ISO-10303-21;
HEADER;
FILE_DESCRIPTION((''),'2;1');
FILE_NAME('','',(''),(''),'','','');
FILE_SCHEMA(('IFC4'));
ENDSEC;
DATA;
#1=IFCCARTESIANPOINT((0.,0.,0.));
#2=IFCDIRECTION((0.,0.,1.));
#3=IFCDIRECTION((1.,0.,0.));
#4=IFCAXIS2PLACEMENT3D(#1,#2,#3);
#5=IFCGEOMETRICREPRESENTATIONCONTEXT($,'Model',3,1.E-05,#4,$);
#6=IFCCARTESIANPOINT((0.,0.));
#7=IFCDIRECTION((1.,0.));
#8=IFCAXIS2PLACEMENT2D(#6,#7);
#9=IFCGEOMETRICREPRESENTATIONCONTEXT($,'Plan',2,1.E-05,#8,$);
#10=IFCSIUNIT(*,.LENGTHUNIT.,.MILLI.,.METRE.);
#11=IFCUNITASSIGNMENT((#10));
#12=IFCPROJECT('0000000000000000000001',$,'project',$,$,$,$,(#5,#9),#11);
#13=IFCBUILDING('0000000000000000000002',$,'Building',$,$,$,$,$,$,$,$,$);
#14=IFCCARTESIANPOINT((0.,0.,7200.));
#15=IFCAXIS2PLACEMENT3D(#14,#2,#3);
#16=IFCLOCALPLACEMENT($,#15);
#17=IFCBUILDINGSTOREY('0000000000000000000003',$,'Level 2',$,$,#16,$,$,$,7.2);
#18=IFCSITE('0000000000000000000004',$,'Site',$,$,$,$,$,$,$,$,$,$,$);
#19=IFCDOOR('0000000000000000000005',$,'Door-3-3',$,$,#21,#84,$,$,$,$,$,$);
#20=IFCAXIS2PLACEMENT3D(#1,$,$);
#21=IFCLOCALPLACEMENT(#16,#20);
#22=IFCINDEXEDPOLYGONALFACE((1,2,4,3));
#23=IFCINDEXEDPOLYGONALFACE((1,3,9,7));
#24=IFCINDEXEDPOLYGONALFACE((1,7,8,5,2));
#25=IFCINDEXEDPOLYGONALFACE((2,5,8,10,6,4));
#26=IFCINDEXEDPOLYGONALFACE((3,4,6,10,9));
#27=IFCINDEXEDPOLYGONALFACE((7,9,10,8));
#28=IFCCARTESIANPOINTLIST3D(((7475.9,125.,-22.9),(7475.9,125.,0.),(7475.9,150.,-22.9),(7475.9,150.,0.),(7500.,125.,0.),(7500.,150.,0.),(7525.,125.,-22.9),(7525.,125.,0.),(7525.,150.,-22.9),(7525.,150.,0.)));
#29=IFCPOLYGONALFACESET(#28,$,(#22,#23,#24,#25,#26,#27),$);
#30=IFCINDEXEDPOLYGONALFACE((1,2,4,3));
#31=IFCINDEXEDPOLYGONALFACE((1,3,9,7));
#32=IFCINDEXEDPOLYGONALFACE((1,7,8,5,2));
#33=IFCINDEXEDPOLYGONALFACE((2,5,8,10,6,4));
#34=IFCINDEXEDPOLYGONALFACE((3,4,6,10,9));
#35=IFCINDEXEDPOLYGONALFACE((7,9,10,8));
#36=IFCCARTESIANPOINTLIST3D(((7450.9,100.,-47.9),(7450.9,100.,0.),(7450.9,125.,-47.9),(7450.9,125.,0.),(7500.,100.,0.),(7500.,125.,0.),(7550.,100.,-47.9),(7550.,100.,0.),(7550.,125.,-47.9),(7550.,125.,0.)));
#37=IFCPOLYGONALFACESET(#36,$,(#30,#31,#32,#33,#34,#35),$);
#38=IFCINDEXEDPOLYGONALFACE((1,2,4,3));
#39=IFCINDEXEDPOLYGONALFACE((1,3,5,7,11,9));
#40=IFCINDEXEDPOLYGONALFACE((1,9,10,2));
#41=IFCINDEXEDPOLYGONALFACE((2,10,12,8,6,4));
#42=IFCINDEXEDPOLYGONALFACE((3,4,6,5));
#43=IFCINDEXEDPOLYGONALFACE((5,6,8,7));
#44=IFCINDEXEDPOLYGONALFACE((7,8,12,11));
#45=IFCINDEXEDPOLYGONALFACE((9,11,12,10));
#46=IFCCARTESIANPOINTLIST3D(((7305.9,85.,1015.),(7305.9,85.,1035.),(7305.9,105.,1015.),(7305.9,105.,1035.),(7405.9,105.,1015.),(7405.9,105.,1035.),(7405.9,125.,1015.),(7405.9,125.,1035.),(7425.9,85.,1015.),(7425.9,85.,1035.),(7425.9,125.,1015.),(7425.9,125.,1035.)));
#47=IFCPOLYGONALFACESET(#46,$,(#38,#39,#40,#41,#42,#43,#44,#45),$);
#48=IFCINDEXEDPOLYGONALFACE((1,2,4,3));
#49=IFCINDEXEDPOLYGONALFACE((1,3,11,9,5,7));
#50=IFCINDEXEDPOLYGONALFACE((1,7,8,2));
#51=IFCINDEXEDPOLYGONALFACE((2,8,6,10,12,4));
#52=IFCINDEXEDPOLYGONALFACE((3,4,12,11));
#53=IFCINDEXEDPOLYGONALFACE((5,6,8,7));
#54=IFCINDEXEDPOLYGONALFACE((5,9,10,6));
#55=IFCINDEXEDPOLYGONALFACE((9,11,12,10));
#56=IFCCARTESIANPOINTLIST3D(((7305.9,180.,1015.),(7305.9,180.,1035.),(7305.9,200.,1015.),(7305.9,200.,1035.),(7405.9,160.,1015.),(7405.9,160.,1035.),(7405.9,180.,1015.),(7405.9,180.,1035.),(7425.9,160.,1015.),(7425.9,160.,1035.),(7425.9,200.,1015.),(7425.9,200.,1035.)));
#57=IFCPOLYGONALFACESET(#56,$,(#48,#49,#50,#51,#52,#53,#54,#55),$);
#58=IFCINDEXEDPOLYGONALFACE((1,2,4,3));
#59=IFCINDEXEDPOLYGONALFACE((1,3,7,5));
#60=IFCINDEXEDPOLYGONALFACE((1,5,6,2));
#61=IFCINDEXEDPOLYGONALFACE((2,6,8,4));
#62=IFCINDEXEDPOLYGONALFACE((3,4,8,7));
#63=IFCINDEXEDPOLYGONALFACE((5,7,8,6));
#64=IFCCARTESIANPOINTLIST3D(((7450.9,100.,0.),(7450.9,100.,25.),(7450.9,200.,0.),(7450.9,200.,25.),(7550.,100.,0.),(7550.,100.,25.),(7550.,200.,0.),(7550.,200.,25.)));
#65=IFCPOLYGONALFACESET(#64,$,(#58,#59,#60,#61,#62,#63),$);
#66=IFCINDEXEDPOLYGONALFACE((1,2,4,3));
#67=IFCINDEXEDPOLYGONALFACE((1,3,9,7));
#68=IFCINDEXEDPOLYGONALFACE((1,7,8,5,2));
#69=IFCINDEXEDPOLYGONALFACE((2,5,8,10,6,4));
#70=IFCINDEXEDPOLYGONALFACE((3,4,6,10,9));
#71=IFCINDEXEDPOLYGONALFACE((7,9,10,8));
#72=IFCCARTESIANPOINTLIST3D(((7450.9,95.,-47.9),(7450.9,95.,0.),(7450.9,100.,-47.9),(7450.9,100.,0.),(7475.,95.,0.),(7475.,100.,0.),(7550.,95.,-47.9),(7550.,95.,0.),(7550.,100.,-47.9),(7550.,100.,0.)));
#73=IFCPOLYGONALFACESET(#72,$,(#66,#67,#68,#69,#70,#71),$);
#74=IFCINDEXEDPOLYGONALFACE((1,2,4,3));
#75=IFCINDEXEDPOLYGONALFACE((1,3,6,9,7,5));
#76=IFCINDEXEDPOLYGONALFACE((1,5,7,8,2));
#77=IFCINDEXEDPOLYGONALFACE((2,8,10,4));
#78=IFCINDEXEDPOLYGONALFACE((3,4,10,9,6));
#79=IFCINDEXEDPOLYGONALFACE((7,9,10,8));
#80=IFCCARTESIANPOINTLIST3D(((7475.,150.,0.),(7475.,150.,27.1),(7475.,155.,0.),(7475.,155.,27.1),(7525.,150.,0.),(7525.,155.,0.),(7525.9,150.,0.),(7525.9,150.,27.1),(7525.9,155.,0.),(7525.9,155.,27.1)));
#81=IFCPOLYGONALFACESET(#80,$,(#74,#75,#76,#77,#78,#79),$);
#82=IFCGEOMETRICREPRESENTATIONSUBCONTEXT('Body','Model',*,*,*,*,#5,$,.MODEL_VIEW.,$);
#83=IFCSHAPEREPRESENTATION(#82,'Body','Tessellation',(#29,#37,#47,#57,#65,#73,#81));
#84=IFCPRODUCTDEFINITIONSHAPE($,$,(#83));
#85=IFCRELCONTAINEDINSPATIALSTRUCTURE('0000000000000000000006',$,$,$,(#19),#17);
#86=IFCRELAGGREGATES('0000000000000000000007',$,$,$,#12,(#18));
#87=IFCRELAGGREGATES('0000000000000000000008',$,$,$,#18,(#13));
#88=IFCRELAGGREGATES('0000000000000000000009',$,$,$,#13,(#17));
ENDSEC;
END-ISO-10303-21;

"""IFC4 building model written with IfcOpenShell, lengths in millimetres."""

from ifc_helpers import new_model, si_unit, frame, origin_with_axes, origin_2d_with_axis, place, context, subcontext, project, spatial, line, indexed_curve, outline, extrude, element, save


model = new_model("IFC4")

# Units and contexts
model_context = context("Model", 3, precision=1e-05, world=origin_with_axes())
plan_context = context("Plan", 2, precision=1e-05, world=origin_2d_with_axis())
body_context = subcontext(model_context, "Body", "Model", "MODEL_VIEW")
ifc_project = project(units=[si_unit("LENGTHUNIT", "METRE", prefix="MILLI")], contexts=[model_context, plan_context])

# Site, building, storey
site = spatial("IfcSite", under=ifc_project, Name="Site")
building = spatial("IfcBuilding", under=site, Name="Building")
storey_placement = place(None, frame((0.0, 0.0, 7200.0), z_axis=(0.0, 0.0, 1.0), x_axis=(1.0, 0.0, 0.0)))
storey = spatial("IfcBuildingStorey", under=building, at=storey_placement, Name="Level 2", Elevation=7.2)

# Door
door_1_placement = place(storey_placement, frame((7500.0, 100.0, 0.0), z_axis=(0.0, 0.0, 1.0), x_axis=(1.0, 0.0, 0.0)))
element("IfcDoor", 1, at=door_1_placement, inside=storey, Name="Door-3-3", context=body_context, shape_type="SweptSolid", body=[
    extrude(outline(indexed_curve([(0.0, 0.0), (0.0, 2.1), (0.9, 2.1), (0.9, 0.0), (-24.1, 0.0), (-24.1, -22.9), (25.0, -22.9), (25.0, 0.0)], segments=[line(1, 2, 3, 4, 5, 6, 7, 8, 1)])), frame((0.0, 25.0, 0.0), z_axis=(0.0, -1.0, 0.0), x_axis=(1.0, 0.0, 0.0)), (0.0, 0.0, -1.0), 25.0),
    extrude(outline(indexed_curve([(0.0, 0.0), (0.0, 2.1), (0.9, 2.1), (0.9, 0.0), (-49.1, 0.0), (-49.1, -47.9), (50.0, -47.9), (50.0, 0.0)], segments=[line(1, 2, 3, 4, 5, 6, 7, 8, 1)])), frame((0.0, 0.0, 0.0), z_axis=(0.0, -1.0, 0.0), x_axis=(1.0, 0.0, 0.0)), (0.0, 0.0, -1.0), 25.0),
    extrude(outline(indexed_curve([(0.0, 0.0), (-49.1, 0.0), (-49.1, 35.0), (0.0, 35.0)], segments=[line(1, 2, 3, 4, 1)])), frame((25.0, 25.0, 25.0), z_axis=(0.0, 0.0, 1.0), x_axis=(1.0, 0.0, 0.0)), (0.0, 0.0, 1.0), -47.9),
    extrude(outline(indexed_curve([(0.0, 0.0), (0.0, -40.0), (-120.0, -40.0), (-120.0, -20.0), (-20.0, -20.0), (-20.0, 0.0)], segments=[line(1, 2, 3, 4, 5, 6, 1)])), frame((-74.1, 25.0, 1015.0), z_axis=(0.0, 0.0, 1.0), x_axis=(1.0, 0.0, 0.0)), (0.0, 0.0, 1.0), 20.0),
    extrude(outline(indexed_curve([(0.0, 0.0), (0.0, 40.0), (-120.0, 40.0), (-120.0, 20.0), (-20.0, 20.0), (-20.0, 0.0)], segments=[line(1, 2, 3, 4, 5, 6, 1)])), frame((-74.1, 60.0, 1015.0), z_axis=(0.0, 0.0, 1.0), x_axis=(1.0, 0.0, 0.0)), (0.0, 0.0, 1.0), 20.0),
    extrude(outline(indexed_curve([(0.0, 0.0), (-99.1, 0.0), (-99.1, 100.0), (0.0, 100.0)], segments=[line(1, 2, 3, 4, 1)])), frame((50.0, 0.0, 0.0), z_axis=(0.0, 0.0, 1.0), x_axis=(1.0, 0.0, 0.0)), (0.0, 0.0, 1.0), 25.0),
    extrude(outline(indexed_curve([(0.0, 0.0), (0.0, 27.1), (50.9, 27.1), (50.9, 0.0), (-24.1, 0.0), (-24.1, -47.9), (75.0, -47.9), (75.0, 0.0)], segments=[line(1, 2, 3, 4, 5, 6, 7, 8, 1)])), frame((-25.0, -5.0, 0.0), z_axis=(0.0, -1.0, 0.0), x_axis=(1.0, 0.0, 0.0)), (0.0, 0.0, -1.0), 5.0),
    extrude(outline(indexed_curve([(0.0, 0.0), (0.0, 27.1), (50.9, 27.1), (50.9, 0.0), (0.9, 0.0), (0.9, -22.9), (50.0, -22.9), (50.0, 0.0)], segments=[line(1, 2, 3, 4, 5, 6, 7, 8, 1)])), frame((-25.0, 50.0, 0.0), z_axis=(0.0, -1.0, 0.0), x_axis=(1.0, 0.0, 0.0)), (0.0, 0.0, -1.0), 5.0),
])

save(model, "model.ifc")
